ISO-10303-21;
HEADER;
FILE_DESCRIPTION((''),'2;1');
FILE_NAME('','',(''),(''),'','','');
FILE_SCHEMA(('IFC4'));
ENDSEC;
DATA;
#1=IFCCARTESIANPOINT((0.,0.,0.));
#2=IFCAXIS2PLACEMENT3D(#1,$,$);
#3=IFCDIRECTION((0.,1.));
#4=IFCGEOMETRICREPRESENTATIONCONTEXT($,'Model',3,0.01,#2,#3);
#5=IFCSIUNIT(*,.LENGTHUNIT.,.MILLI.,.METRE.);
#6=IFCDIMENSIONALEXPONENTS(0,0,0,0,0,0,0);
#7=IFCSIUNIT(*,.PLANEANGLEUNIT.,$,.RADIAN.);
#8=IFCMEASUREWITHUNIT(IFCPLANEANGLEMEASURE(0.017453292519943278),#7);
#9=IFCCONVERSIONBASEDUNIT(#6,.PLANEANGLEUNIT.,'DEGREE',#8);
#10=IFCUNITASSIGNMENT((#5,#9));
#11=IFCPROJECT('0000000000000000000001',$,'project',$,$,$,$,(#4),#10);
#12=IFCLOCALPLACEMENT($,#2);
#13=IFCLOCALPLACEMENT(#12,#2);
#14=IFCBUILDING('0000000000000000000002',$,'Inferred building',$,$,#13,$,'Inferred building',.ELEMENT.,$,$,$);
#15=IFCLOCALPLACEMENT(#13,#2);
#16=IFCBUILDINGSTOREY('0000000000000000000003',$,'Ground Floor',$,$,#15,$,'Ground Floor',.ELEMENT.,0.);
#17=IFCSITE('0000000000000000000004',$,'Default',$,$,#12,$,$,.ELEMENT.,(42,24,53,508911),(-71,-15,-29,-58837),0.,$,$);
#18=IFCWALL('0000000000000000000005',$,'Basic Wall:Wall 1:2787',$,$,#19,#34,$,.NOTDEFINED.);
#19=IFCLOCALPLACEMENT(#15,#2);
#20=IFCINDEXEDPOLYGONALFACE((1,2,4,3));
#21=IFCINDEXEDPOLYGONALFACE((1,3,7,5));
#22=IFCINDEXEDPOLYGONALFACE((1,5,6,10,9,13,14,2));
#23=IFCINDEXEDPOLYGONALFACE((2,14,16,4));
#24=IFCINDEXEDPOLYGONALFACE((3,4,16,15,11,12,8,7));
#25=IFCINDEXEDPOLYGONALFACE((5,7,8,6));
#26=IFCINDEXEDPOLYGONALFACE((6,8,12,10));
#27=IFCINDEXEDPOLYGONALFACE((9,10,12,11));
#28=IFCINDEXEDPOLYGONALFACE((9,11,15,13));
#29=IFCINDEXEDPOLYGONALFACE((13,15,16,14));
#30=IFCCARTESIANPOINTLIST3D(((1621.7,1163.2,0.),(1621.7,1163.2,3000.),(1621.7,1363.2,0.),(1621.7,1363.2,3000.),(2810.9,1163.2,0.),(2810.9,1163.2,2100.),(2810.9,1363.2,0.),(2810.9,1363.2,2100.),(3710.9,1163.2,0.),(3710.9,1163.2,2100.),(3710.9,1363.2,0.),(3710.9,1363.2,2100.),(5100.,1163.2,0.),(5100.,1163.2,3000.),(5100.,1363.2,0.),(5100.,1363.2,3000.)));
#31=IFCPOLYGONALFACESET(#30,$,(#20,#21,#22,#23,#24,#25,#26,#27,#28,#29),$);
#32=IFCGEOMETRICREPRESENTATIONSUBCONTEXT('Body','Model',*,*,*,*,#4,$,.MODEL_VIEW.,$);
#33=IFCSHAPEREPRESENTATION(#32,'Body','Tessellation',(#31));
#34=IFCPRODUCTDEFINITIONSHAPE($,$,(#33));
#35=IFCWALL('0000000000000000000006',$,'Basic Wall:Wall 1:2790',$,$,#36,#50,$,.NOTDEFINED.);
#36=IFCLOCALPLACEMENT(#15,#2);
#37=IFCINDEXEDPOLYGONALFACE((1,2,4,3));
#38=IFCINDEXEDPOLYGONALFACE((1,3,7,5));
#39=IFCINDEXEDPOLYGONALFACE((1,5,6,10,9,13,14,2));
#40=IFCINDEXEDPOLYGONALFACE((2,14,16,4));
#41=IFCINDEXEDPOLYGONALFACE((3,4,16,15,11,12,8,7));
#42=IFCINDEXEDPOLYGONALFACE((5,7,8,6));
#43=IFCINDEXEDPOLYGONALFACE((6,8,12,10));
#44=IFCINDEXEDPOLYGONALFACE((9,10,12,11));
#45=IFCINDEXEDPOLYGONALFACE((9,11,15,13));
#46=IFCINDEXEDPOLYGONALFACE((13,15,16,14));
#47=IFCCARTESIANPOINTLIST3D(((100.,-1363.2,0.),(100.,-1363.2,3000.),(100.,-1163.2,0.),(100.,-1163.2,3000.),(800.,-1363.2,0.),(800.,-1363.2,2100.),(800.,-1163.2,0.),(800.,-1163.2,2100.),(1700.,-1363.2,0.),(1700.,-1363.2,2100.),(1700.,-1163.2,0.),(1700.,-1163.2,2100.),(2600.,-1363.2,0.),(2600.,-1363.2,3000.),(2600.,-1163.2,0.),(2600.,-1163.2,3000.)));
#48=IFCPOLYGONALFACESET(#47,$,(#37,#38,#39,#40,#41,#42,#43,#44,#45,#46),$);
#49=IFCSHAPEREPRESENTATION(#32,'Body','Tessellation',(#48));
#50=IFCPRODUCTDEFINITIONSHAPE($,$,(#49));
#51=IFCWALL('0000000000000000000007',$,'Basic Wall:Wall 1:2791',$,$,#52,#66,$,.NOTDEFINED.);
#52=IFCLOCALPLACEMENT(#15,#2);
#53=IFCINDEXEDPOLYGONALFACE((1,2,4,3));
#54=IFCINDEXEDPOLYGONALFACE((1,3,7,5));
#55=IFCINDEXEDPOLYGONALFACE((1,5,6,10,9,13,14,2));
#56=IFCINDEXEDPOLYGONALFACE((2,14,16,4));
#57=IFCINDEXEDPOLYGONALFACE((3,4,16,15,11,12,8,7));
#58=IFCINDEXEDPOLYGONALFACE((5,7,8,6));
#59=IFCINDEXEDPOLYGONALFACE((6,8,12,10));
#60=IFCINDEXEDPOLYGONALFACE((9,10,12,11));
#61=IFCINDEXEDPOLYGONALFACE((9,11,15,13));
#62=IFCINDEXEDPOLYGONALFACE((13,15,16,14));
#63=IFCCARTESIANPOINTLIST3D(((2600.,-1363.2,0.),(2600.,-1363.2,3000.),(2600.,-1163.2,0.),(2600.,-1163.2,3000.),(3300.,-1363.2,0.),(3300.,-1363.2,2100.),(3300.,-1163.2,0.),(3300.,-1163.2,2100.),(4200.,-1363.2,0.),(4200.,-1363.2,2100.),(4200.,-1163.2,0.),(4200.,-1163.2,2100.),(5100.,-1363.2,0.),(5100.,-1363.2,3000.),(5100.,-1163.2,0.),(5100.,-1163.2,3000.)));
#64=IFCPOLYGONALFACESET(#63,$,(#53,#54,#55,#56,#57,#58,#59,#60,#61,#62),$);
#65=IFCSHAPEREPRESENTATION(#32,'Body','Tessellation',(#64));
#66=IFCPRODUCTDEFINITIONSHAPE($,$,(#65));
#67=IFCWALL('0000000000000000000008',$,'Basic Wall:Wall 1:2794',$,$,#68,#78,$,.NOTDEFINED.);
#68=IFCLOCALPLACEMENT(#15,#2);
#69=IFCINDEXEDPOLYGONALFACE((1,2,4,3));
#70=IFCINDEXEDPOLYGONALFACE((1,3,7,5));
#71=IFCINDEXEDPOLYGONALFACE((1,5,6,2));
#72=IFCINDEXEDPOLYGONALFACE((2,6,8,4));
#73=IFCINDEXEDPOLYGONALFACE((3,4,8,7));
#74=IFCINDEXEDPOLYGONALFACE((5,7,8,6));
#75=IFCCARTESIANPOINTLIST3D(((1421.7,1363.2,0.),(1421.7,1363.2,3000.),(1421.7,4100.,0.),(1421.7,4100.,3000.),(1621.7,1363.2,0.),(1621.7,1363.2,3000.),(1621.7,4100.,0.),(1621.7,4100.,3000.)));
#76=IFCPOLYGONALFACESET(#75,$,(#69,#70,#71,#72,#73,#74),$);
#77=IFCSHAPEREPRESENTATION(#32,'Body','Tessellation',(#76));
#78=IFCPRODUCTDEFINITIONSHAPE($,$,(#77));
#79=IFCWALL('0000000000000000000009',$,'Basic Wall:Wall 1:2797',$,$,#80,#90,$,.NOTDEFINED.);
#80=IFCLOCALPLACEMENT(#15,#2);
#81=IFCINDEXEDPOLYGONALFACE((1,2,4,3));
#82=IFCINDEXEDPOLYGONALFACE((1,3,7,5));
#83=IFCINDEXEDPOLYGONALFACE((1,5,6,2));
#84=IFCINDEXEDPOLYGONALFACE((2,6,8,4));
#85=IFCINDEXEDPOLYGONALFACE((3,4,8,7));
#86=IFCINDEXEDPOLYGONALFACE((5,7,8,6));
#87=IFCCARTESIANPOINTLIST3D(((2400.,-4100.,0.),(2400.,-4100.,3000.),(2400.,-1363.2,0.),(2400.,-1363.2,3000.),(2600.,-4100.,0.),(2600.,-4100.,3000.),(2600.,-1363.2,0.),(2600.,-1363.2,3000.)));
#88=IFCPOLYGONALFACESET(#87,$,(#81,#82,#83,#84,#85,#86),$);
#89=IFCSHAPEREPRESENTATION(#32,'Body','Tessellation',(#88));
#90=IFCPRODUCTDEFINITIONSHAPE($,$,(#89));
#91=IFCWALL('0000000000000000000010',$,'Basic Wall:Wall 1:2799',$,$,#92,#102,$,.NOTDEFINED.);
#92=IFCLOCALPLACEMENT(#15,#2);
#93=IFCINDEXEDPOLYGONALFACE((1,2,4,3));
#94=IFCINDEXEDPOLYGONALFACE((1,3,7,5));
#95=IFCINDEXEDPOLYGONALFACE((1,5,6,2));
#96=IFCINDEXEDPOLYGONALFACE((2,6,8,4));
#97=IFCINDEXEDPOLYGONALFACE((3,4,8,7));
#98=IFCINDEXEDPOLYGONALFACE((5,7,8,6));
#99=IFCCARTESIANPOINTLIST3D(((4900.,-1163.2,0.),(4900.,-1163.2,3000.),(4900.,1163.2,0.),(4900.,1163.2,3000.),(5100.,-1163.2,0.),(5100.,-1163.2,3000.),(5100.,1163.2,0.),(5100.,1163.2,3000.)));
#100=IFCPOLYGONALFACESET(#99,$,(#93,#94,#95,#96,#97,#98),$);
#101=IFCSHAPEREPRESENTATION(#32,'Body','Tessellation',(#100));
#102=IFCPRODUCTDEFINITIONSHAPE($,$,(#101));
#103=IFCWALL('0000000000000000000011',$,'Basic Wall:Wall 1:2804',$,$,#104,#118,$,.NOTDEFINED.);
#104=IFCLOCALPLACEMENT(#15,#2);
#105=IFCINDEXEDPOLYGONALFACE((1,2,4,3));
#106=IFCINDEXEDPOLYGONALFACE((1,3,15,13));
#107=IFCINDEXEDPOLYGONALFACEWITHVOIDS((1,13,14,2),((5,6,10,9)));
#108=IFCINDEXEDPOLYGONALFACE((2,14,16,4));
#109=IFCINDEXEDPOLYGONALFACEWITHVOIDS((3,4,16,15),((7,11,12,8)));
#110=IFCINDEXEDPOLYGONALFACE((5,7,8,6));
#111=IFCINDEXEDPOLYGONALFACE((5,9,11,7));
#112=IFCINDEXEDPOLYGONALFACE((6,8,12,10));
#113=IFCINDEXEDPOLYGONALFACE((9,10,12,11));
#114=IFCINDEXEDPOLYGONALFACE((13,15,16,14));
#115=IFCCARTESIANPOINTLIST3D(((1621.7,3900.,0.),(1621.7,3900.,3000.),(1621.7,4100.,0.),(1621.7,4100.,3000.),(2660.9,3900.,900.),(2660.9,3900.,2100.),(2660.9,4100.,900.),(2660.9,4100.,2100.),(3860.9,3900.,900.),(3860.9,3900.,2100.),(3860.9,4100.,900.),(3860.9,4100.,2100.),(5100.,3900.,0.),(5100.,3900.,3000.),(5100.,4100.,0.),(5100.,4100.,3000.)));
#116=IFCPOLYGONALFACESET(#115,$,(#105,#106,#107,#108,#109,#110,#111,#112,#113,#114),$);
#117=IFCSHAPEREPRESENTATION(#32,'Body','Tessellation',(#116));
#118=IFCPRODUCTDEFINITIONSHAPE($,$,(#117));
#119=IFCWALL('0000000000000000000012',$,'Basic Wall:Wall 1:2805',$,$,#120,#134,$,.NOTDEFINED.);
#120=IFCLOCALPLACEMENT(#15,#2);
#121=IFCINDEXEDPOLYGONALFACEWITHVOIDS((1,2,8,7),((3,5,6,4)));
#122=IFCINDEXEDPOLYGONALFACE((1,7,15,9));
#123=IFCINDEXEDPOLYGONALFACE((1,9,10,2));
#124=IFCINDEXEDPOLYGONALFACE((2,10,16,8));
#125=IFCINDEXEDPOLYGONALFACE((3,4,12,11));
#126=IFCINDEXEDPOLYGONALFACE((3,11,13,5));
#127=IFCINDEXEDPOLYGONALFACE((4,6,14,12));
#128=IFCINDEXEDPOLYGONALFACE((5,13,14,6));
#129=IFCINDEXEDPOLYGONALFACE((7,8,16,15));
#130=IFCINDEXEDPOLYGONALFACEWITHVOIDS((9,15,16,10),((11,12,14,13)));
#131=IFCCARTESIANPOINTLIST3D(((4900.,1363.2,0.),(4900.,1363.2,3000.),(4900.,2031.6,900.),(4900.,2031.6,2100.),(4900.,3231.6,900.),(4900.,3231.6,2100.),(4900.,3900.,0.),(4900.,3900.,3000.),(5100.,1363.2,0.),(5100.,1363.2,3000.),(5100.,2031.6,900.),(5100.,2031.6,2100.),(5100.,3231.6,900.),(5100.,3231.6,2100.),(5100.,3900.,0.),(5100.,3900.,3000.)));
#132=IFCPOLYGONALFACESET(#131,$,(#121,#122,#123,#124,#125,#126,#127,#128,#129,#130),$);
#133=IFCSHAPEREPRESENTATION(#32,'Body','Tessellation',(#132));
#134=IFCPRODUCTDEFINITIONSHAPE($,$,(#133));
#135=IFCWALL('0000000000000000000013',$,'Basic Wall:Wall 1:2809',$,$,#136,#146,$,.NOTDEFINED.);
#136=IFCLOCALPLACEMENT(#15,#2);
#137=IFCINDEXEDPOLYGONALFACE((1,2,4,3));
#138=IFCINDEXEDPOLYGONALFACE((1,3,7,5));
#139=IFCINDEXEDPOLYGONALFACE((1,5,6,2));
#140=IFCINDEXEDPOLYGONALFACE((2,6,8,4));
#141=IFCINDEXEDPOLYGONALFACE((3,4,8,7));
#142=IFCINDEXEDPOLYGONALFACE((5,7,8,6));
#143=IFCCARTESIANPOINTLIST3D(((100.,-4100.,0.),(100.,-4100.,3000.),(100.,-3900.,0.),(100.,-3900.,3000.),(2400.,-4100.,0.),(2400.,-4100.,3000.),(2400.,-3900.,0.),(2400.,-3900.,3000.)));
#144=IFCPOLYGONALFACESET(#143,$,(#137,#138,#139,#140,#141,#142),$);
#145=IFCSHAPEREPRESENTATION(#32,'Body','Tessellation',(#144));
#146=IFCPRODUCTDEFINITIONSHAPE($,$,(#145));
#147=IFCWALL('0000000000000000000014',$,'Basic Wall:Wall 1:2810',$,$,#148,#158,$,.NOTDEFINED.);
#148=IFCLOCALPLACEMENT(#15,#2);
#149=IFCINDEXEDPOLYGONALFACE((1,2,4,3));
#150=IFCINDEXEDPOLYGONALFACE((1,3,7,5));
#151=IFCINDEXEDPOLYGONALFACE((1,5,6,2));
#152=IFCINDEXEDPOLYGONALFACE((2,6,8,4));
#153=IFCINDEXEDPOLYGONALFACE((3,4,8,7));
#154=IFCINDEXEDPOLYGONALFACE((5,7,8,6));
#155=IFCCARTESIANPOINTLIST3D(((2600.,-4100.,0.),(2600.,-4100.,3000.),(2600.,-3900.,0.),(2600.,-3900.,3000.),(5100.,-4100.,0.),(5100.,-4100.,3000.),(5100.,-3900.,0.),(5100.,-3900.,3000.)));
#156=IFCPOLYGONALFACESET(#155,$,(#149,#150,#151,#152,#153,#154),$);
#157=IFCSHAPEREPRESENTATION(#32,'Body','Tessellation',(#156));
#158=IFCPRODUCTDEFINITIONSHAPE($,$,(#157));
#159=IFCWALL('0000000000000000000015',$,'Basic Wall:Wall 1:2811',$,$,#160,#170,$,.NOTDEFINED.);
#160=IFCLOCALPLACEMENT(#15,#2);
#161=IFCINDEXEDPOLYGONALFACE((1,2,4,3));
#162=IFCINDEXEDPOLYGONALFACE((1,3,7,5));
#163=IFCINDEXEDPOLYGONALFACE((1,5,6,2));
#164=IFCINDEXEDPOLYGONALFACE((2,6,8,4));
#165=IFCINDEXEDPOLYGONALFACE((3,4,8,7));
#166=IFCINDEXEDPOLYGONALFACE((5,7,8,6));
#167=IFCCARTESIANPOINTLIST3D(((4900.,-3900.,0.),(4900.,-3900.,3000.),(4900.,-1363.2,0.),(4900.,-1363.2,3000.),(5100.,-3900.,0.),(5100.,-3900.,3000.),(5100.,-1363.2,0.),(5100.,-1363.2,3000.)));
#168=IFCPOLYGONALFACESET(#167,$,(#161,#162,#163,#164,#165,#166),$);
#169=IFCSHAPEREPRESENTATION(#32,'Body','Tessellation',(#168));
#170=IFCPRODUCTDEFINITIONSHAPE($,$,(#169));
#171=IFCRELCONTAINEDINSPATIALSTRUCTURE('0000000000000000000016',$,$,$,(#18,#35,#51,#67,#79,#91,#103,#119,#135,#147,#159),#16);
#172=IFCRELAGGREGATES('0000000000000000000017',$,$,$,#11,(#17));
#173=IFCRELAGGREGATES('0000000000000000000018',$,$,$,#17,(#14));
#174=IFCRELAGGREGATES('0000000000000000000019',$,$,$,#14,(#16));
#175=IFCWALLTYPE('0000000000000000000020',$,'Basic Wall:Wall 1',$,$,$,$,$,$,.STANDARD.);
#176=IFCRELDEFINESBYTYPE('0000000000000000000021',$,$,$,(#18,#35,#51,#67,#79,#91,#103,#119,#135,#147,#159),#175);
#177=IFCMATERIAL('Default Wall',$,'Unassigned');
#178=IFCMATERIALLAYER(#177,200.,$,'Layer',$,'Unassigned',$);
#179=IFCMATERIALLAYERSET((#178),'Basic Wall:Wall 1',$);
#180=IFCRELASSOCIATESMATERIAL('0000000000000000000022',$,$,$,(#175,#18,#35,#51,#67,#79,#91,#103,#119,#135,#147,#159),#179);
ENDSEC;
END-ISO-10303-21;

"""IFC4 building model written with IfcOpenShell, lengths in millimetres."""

from ifc_helpers import new_model, entity, si_unit, converted_unit, direction, frame, frame_2d, origin, origin_2d_with_axis, place, context, subcontext, project, spatial, rectangle, extrude, material, layer, layer_set, layer_usage, type_object, element, save


model = new_model("IFC4")

# Units and contexts
model_context = context("Model", 3, precision=0.01, world=origin(), true_north=direction((0.0, 1.0)))
body_context = subcontext(model_context, "Body", "Model", "MODEL_VIEW")
ifc_project = project(units=[si_unit("LENGTHUNIT", "METRE", prefix="MILLI"), converted_unit("PLANEANGLEUNIT", "DEGREE", entity("IfcPlaneAngleMeasure", 0.017453292519943278), si_unit("PLANEANGLEUNIT", "RADIAN"), dimensions=[0, 0, 0, 0, 0, 0, 0])], contexts=[model_context])

# Site, building, storey
site_placement = place(None, origin())
site = spatial("IfcSite", under=ifc_project, at=site_placement, Name="Default", CompositionType="ELEMENT", RefLatitude=(42, 24, 53, 508911), RefLongitude=(-71, -15, -29, -58837), RefElevation=0.0)
building_placement = place(site_placement, origin())
building = spatial("IfcBuilding", under=site, at=building_placement, Name="Inferred building", LongName="Inferred building", CompositionType="ELEMENT")
storey_placement = place(building_placement, origin())
storey = spatial("IfcBuildingStorey", under=building, at=storey_placement, Name="Ground Floor", LongName="Ground Floor", CompositionType="ELEMENT", Elevation=0.0)

# Walls, openings
ifc_material = material(Name="Default Wall", Category="Unassigned")
ifc_layer = layer(ifc_material, 200.0, Name="Layer", Category="Unassigned")
ifc_layer_set = layer_set([ifc_layer], Name="Basic Wall:Wall 1")
ifc_layer_usage_1 = layer_usage(ifc_layer_set, "AXIS2", "NEGATIVE", 100.0)
wall_type = type_object("IfcWallType", Name="Basic Wall:Wall 1", PredefinedType="STANDARD", material=ifc_layer_set)
wall_1_placement = place(storey_placement, frame((1621.7, 1263.2, 0.0)))
wall_1 = element("IfcWall", 1, at=wall_1_placement, inside=storey, type_object=wall_type, material=ifc_layer_usage_1, Name="Basic Wall:Wall 1:2787", PredefinedType="NOTDEFINED", context=body_context, shape_type="SweptSolid", body=[
    extrude(rectangle(XDim=3478.3, YDim=200.0, at=frame_2d((1739.1, 0.0), x_axis=(1.0, 0.0))), origin(), (0.0, 0.0, 1.0), 3000.0),
])
opening_1_placement = place(wall_1_placement, origin())
element("IfcOpeningElement", 2, at=opening_1_placement, cuts=wall_1, PredefinedType="OPENING", context=body_context, shape_type="SweptSolid", body=[
    extrude(rectangle(XDim=2100.0, YDim=900.0, at=origin_2d_with_axis()), frame((1639.1, -100.0, 1050.0), z_axis=(0.0, 1.0, 0.0), x_axis=(0.0, 0.0, -1.0)), (0.0, 0.0, 1.0), 200.0),
])
ifc_layer_usage_2 = layer_usage(ifc_layer_set, "AXIS2", "NEGATIVE", 100.0)
wall_2_placement = place(storey_placement, frame((100.0, -1263.2, 0.0)))
wall_2 = element("IfcWall", 3, at=wall_2_placement, inside=storey, type_object=wall_type, material=ifc_layer_usage_2, Name="Basic Wall:Wall 1:2790", PredefinedType="NOTDEFINED", context=body_context, shape_type="SweptSolid", body=[
    extrude(rectangle(XDim=2500.0, YDim=200.0, at=frame_2d((1250.0, 0.0), x_axis=(1.0, 0.0))), origin(), (0.0, 0.0, 1.0), 3000.0),
])
opening_2_placement = place(wall_2_placement, origin())
element("IfcOpeningElement", 4, at=opening_2_placement, cuts=wall_2, PredefinedType="OPENING", context=body_context, shape_type="SweptSolid", body=[
    extrude(rectangle(XDim=2100.0, YDim=900.0, at=origin_2d_with_axis()), frame((1150.0, -100.0, 1050.0), z_axis=(0.0, 1.0, 0.0), x_axis=(0.0, 0.0, -1.0)), (0.0, 0.0, 1.0), 200.0),
])
ifc_layer_usage_3 = layer_usage(ifc_layer_set, "AXIS2", "NEGATIVE", 100.0)
wall_3_placement = place(storey_placement, frame((2600.0, -1263.2, 0.0)))
wall_3 = element("IfcWall", 5, at=wall_3_placement, inside=storey, type_object=wall_type, material=ifc_layer_usage_3, Name="Basic Wall:Wall 1:2791", PredefinedType="NOTDEFINED", context=body_context, shape_type="SweptSolid", body=[
    extrude(rectangle(XDim=2500.0, YDim=200.0, at=frame_2d((1250.0, 0.0), x_axis=(-1.0, 0.0))), origin(), (0.0, 0.0, 1.0), 3000.0),
])
opening_3_placement = place(wall_3_placement, origin())
element("IfcOpeningElement", 6, at=opening_3_placement, cuts=wall_3, PredefinedType="OPENING", context=body_context, shape_type="SweptSolid", body=[
    extrude(rectangle(XDim=2100.0, YDim=900.0, at=frame_2d((0.0, 0.0), x_axis=(1.0, 0.0))), frame((1150.0, -100.0, 1050.0), z_axis=(0.0, 1.0, 0.0), x_axis=(0.0, 0.0, -1.0)), (0.0, 0.0, 1.0), 200.0),
])

# Walls
ifc_layer_usage_4 = layer_usage(ifc_layer_set, "AXIS2", "NEGATIVE", 100.0)
wall_4_placement = place(storey_placement, frame((1521.7, 1363.2, 0.0), z_axis=(0.0, 0.0, 1.0), x_axis=(0.0, 1.0, 0.0)))
element("IfcWall", 7, at=wall_4_placement, inside=storey, type_object=wall_type, material=ifc_layer_usage_4, Name="Basic Wall:Wall 1:2794", PredefinedType="NOTDEFINED", context=body_context, shape_type="SweptSolid", body=[
    extrude(rectangle(XDim=2736.8, YDim=200.0, at=frame_2d((1368.4, 0.0), x_axis=(-1.0, 0.0))), origin(), (0.0, 0.0, 1.0), 3000.0),
])
ifc_layer_usage_5 = layer_usage(ifc_layer_set, "AXIS2", "NEGATIVE", 100.0)
wall_5_placement = place(storey_placement, frame((2500.0, -4100.0, 0.0), z_axis=(0.0, 0.0, 1.0), x_axis=(0.0, 1.0, 0.0)))
element("IfcWall", 8, at=wall_5_placement, inside=storey, type_object=wall_type, material=ifc_layer_usage_5, Name="Basic Wall:Wall 1:2797", PredefinedType="NOTDEFINED", context=body_context, shape_type="SweptSolid", body=[
    extrude(rectangle(XDim=2736.8, YDim=200.0, at=frame_2d((1368.4, 0.0), x_axis=(-1.0, 0.0))), origin(), (0.0, 0.0, 1.0), 3000.0),
])
ifc_layer_usage_6 = layer_usage(ifc_layer_set, "AXIS2", "NEGATIVE", 100.0)
wall_6_placement = place(storey_placement, frame((5000.0, -1163.2, 0.0), z_axis=(0.0, 0.0, 1.0), x_axis=(0.0, 1.0, 0.0)))
element("IfcWall", 9, at=wall_6_placement, inside=storey, type_object=wall_type, material=ifc_layer_usage_6, Name="Basic Wall:Wall 1:2799", PredefinedType="NOTDEFINED", context=body_context, shape_type="SweptSolid", body=[
    extrude(rectangle(XDim=2326.3, YDim=200.0, at=frame_2d((1163.2, 0.0), x_axis=(-1.0, 0.0))), origin(), (0.0, 0.0, 1.0), 3000.0),
])

# Walls, openings
ifc_layer_usage_7 = layer_usage(ifc_layer_set, "AXIS2", "NEGATIVE", 100.0)
wall_7_placement = place(storey_placement, frame((1621.7, 4000.0, 0.0)))
wall_7 = element("IfcWall", 10, at=wall_7_placement, inside=storey, type_object=wall_type, material=ifc_layer_usage_7, Name="Basic Wall:Wall 1:2804", PredefinedType="NOTDEFINED", context=body_context, shape_type="SweptSolid", body=[
    extrude(rectangle(XDim=3478.3, YDim=200.0, at=frame_2d((1739.1, 0.0), x_axis=(-1.0, 0.0))), origin(), (0.0, 0.0, 1.0), 3000.0),
])
opening_4_placement = place(wall_7_placement, origin())
element("IfcOpeningElement", 11, at=opening_4_placement, cuts=wall_7, PredefinedType="OPENING", context=body_context, shape_type="SweptSolid", body=[
    extrude(rectangle(XDim=1200.0, YDim=1200.0, at=frame_2d((0.0, 0.0), x_axis=(1.0, 0.0))), frame((1639.1, -100.0, 1500.0), z_axis=(0.0, 1.0, 0.0), x_axis=(0.0, 0.0, -1.0)), (0.0, 0.0, 1.0), 200.0),
])
ifc_layer_usage_8 = layer_usage(ifc_layer_set, "AXIS2", "NEGATIVE", 100.0)
wall_8_placement = place(storey_placement, frame((5000.0, 1363.2, 0.0), z_axis=(0.0, 0.0, 1.0), x_axis=(0.0, 1.0, 0.0)))
wall_8 = element("IfcWall", 12, at=wall_8_placement, inside=storey, type_object=wall_type, material=ifc_layer_usage_8, Name="Basic Wall:Wall 1:2805", PredefinedType="NOTDEFINED", context=body_context, shape_type="SweptSolid", body=[
    extrude(rectangle(XDim=2536.8, YDim=200.0, at=frame_2d((1268.4, 0.0), x_axis=(-1.0, 0.0))), origin(), (0.0, 0.0, 1.0), 3000.0),
])
opening_5_placement = place(wall_8_placement, origin())
element("IfcOpeningElement", 13, at=opening_5_placement, cuts=wall_8, PredefinedType="OPENING", context=body_context, shape_type="SweptSolid", body=[
    extrude(rectangle(XDim=1200.0, YDim=1200.0, at=frame_2d((0.0, 0.0), x_axis=(1.0, 0.0))), frame((1268.4, -100.0, 1500.0), z_axis=(0.0, 1.0, 0.0), x_axis=(0.0, 0.0, -1.0)), (0.0, 0.0, 1.0), 200.0),
])

# Walls
ifc_layer_usage_9 = layer_usage(ifc_layer_set, "AXIS2", "NEGATIVE", 100.0)
wall_9_placement = place(storey_placement, frame((100.0, -4000.0, 0.0)))
element("IfcWall", 14, at=wall_9_placement, inside=storey, type_object=wall_type, material=ifc_layer_usage_9, Name="Basic Wall:Wall 1:2809", PredefinedType="NOTDEFINED", context=body_context, shape_type="SweptSolid", body=[
    extrude(rectangle(XDim=2300.0, YDim=200.0, at=frame_2d((1150.0, 0.0), x_axis=(-1.0, 0.0))), origin(), (0.0, 0.0, 1.0), 3000.0),
])
ifc_layer_usage_10 = layer_usage(ifc_layer_set, "AXIS2", "NEGATIVE", 100.0)
wall_10_placement = place(storey_placement, frame((2600.0, -4000.0, 0.0)))
element("IfcWall", 15, at=wall_10_placement, inside=storey, type_object=wall_type, material=ifc_layer_usage_10, Name="Basic Wall:Wall 1:2810", PredefinedType="NOTDEFINED", context=body_context, shape_type="SweptSolid", body=[
    extrude(rectangle(XDim=2500.0, YDim=200.0, at=frame_2d((1250.0, 0.0), x_axis=(-1.0, 0.0))), origin(), (0.0, 0.0, 1.0), 3000.0),
])
ifc_layer_usage_11 = layer_usage(ifc_layer_set, "AXIS2", "NEGATIVE", 100.0)
wall_11_placement = place(storey_placement, frame((5000.0, -3900.0, 0.0), z_axis=(0.0, 0.0, 1.0), x_axis=(0.0, 1.0, 0.0)))
element("IfcWall", 16, at=wall_11_placement, inside=storey, type_object=wall_type, material=ifc_layer_usage_11, Name="Basic Wall:Wall 1:2811", PredefinedType="NOTDEFINED", context=body_context, shape_type="SweptSolid", body=[
    extrude(rectangle(XDim=2536.8, YDim=200.0, at=frame_2d((1268.4, 0.0), x_axis=(-1.0, 0.0))), origin(), (0.0, 0.0, 1.0), 3000.0),
])

save(model, "model.ifc")
